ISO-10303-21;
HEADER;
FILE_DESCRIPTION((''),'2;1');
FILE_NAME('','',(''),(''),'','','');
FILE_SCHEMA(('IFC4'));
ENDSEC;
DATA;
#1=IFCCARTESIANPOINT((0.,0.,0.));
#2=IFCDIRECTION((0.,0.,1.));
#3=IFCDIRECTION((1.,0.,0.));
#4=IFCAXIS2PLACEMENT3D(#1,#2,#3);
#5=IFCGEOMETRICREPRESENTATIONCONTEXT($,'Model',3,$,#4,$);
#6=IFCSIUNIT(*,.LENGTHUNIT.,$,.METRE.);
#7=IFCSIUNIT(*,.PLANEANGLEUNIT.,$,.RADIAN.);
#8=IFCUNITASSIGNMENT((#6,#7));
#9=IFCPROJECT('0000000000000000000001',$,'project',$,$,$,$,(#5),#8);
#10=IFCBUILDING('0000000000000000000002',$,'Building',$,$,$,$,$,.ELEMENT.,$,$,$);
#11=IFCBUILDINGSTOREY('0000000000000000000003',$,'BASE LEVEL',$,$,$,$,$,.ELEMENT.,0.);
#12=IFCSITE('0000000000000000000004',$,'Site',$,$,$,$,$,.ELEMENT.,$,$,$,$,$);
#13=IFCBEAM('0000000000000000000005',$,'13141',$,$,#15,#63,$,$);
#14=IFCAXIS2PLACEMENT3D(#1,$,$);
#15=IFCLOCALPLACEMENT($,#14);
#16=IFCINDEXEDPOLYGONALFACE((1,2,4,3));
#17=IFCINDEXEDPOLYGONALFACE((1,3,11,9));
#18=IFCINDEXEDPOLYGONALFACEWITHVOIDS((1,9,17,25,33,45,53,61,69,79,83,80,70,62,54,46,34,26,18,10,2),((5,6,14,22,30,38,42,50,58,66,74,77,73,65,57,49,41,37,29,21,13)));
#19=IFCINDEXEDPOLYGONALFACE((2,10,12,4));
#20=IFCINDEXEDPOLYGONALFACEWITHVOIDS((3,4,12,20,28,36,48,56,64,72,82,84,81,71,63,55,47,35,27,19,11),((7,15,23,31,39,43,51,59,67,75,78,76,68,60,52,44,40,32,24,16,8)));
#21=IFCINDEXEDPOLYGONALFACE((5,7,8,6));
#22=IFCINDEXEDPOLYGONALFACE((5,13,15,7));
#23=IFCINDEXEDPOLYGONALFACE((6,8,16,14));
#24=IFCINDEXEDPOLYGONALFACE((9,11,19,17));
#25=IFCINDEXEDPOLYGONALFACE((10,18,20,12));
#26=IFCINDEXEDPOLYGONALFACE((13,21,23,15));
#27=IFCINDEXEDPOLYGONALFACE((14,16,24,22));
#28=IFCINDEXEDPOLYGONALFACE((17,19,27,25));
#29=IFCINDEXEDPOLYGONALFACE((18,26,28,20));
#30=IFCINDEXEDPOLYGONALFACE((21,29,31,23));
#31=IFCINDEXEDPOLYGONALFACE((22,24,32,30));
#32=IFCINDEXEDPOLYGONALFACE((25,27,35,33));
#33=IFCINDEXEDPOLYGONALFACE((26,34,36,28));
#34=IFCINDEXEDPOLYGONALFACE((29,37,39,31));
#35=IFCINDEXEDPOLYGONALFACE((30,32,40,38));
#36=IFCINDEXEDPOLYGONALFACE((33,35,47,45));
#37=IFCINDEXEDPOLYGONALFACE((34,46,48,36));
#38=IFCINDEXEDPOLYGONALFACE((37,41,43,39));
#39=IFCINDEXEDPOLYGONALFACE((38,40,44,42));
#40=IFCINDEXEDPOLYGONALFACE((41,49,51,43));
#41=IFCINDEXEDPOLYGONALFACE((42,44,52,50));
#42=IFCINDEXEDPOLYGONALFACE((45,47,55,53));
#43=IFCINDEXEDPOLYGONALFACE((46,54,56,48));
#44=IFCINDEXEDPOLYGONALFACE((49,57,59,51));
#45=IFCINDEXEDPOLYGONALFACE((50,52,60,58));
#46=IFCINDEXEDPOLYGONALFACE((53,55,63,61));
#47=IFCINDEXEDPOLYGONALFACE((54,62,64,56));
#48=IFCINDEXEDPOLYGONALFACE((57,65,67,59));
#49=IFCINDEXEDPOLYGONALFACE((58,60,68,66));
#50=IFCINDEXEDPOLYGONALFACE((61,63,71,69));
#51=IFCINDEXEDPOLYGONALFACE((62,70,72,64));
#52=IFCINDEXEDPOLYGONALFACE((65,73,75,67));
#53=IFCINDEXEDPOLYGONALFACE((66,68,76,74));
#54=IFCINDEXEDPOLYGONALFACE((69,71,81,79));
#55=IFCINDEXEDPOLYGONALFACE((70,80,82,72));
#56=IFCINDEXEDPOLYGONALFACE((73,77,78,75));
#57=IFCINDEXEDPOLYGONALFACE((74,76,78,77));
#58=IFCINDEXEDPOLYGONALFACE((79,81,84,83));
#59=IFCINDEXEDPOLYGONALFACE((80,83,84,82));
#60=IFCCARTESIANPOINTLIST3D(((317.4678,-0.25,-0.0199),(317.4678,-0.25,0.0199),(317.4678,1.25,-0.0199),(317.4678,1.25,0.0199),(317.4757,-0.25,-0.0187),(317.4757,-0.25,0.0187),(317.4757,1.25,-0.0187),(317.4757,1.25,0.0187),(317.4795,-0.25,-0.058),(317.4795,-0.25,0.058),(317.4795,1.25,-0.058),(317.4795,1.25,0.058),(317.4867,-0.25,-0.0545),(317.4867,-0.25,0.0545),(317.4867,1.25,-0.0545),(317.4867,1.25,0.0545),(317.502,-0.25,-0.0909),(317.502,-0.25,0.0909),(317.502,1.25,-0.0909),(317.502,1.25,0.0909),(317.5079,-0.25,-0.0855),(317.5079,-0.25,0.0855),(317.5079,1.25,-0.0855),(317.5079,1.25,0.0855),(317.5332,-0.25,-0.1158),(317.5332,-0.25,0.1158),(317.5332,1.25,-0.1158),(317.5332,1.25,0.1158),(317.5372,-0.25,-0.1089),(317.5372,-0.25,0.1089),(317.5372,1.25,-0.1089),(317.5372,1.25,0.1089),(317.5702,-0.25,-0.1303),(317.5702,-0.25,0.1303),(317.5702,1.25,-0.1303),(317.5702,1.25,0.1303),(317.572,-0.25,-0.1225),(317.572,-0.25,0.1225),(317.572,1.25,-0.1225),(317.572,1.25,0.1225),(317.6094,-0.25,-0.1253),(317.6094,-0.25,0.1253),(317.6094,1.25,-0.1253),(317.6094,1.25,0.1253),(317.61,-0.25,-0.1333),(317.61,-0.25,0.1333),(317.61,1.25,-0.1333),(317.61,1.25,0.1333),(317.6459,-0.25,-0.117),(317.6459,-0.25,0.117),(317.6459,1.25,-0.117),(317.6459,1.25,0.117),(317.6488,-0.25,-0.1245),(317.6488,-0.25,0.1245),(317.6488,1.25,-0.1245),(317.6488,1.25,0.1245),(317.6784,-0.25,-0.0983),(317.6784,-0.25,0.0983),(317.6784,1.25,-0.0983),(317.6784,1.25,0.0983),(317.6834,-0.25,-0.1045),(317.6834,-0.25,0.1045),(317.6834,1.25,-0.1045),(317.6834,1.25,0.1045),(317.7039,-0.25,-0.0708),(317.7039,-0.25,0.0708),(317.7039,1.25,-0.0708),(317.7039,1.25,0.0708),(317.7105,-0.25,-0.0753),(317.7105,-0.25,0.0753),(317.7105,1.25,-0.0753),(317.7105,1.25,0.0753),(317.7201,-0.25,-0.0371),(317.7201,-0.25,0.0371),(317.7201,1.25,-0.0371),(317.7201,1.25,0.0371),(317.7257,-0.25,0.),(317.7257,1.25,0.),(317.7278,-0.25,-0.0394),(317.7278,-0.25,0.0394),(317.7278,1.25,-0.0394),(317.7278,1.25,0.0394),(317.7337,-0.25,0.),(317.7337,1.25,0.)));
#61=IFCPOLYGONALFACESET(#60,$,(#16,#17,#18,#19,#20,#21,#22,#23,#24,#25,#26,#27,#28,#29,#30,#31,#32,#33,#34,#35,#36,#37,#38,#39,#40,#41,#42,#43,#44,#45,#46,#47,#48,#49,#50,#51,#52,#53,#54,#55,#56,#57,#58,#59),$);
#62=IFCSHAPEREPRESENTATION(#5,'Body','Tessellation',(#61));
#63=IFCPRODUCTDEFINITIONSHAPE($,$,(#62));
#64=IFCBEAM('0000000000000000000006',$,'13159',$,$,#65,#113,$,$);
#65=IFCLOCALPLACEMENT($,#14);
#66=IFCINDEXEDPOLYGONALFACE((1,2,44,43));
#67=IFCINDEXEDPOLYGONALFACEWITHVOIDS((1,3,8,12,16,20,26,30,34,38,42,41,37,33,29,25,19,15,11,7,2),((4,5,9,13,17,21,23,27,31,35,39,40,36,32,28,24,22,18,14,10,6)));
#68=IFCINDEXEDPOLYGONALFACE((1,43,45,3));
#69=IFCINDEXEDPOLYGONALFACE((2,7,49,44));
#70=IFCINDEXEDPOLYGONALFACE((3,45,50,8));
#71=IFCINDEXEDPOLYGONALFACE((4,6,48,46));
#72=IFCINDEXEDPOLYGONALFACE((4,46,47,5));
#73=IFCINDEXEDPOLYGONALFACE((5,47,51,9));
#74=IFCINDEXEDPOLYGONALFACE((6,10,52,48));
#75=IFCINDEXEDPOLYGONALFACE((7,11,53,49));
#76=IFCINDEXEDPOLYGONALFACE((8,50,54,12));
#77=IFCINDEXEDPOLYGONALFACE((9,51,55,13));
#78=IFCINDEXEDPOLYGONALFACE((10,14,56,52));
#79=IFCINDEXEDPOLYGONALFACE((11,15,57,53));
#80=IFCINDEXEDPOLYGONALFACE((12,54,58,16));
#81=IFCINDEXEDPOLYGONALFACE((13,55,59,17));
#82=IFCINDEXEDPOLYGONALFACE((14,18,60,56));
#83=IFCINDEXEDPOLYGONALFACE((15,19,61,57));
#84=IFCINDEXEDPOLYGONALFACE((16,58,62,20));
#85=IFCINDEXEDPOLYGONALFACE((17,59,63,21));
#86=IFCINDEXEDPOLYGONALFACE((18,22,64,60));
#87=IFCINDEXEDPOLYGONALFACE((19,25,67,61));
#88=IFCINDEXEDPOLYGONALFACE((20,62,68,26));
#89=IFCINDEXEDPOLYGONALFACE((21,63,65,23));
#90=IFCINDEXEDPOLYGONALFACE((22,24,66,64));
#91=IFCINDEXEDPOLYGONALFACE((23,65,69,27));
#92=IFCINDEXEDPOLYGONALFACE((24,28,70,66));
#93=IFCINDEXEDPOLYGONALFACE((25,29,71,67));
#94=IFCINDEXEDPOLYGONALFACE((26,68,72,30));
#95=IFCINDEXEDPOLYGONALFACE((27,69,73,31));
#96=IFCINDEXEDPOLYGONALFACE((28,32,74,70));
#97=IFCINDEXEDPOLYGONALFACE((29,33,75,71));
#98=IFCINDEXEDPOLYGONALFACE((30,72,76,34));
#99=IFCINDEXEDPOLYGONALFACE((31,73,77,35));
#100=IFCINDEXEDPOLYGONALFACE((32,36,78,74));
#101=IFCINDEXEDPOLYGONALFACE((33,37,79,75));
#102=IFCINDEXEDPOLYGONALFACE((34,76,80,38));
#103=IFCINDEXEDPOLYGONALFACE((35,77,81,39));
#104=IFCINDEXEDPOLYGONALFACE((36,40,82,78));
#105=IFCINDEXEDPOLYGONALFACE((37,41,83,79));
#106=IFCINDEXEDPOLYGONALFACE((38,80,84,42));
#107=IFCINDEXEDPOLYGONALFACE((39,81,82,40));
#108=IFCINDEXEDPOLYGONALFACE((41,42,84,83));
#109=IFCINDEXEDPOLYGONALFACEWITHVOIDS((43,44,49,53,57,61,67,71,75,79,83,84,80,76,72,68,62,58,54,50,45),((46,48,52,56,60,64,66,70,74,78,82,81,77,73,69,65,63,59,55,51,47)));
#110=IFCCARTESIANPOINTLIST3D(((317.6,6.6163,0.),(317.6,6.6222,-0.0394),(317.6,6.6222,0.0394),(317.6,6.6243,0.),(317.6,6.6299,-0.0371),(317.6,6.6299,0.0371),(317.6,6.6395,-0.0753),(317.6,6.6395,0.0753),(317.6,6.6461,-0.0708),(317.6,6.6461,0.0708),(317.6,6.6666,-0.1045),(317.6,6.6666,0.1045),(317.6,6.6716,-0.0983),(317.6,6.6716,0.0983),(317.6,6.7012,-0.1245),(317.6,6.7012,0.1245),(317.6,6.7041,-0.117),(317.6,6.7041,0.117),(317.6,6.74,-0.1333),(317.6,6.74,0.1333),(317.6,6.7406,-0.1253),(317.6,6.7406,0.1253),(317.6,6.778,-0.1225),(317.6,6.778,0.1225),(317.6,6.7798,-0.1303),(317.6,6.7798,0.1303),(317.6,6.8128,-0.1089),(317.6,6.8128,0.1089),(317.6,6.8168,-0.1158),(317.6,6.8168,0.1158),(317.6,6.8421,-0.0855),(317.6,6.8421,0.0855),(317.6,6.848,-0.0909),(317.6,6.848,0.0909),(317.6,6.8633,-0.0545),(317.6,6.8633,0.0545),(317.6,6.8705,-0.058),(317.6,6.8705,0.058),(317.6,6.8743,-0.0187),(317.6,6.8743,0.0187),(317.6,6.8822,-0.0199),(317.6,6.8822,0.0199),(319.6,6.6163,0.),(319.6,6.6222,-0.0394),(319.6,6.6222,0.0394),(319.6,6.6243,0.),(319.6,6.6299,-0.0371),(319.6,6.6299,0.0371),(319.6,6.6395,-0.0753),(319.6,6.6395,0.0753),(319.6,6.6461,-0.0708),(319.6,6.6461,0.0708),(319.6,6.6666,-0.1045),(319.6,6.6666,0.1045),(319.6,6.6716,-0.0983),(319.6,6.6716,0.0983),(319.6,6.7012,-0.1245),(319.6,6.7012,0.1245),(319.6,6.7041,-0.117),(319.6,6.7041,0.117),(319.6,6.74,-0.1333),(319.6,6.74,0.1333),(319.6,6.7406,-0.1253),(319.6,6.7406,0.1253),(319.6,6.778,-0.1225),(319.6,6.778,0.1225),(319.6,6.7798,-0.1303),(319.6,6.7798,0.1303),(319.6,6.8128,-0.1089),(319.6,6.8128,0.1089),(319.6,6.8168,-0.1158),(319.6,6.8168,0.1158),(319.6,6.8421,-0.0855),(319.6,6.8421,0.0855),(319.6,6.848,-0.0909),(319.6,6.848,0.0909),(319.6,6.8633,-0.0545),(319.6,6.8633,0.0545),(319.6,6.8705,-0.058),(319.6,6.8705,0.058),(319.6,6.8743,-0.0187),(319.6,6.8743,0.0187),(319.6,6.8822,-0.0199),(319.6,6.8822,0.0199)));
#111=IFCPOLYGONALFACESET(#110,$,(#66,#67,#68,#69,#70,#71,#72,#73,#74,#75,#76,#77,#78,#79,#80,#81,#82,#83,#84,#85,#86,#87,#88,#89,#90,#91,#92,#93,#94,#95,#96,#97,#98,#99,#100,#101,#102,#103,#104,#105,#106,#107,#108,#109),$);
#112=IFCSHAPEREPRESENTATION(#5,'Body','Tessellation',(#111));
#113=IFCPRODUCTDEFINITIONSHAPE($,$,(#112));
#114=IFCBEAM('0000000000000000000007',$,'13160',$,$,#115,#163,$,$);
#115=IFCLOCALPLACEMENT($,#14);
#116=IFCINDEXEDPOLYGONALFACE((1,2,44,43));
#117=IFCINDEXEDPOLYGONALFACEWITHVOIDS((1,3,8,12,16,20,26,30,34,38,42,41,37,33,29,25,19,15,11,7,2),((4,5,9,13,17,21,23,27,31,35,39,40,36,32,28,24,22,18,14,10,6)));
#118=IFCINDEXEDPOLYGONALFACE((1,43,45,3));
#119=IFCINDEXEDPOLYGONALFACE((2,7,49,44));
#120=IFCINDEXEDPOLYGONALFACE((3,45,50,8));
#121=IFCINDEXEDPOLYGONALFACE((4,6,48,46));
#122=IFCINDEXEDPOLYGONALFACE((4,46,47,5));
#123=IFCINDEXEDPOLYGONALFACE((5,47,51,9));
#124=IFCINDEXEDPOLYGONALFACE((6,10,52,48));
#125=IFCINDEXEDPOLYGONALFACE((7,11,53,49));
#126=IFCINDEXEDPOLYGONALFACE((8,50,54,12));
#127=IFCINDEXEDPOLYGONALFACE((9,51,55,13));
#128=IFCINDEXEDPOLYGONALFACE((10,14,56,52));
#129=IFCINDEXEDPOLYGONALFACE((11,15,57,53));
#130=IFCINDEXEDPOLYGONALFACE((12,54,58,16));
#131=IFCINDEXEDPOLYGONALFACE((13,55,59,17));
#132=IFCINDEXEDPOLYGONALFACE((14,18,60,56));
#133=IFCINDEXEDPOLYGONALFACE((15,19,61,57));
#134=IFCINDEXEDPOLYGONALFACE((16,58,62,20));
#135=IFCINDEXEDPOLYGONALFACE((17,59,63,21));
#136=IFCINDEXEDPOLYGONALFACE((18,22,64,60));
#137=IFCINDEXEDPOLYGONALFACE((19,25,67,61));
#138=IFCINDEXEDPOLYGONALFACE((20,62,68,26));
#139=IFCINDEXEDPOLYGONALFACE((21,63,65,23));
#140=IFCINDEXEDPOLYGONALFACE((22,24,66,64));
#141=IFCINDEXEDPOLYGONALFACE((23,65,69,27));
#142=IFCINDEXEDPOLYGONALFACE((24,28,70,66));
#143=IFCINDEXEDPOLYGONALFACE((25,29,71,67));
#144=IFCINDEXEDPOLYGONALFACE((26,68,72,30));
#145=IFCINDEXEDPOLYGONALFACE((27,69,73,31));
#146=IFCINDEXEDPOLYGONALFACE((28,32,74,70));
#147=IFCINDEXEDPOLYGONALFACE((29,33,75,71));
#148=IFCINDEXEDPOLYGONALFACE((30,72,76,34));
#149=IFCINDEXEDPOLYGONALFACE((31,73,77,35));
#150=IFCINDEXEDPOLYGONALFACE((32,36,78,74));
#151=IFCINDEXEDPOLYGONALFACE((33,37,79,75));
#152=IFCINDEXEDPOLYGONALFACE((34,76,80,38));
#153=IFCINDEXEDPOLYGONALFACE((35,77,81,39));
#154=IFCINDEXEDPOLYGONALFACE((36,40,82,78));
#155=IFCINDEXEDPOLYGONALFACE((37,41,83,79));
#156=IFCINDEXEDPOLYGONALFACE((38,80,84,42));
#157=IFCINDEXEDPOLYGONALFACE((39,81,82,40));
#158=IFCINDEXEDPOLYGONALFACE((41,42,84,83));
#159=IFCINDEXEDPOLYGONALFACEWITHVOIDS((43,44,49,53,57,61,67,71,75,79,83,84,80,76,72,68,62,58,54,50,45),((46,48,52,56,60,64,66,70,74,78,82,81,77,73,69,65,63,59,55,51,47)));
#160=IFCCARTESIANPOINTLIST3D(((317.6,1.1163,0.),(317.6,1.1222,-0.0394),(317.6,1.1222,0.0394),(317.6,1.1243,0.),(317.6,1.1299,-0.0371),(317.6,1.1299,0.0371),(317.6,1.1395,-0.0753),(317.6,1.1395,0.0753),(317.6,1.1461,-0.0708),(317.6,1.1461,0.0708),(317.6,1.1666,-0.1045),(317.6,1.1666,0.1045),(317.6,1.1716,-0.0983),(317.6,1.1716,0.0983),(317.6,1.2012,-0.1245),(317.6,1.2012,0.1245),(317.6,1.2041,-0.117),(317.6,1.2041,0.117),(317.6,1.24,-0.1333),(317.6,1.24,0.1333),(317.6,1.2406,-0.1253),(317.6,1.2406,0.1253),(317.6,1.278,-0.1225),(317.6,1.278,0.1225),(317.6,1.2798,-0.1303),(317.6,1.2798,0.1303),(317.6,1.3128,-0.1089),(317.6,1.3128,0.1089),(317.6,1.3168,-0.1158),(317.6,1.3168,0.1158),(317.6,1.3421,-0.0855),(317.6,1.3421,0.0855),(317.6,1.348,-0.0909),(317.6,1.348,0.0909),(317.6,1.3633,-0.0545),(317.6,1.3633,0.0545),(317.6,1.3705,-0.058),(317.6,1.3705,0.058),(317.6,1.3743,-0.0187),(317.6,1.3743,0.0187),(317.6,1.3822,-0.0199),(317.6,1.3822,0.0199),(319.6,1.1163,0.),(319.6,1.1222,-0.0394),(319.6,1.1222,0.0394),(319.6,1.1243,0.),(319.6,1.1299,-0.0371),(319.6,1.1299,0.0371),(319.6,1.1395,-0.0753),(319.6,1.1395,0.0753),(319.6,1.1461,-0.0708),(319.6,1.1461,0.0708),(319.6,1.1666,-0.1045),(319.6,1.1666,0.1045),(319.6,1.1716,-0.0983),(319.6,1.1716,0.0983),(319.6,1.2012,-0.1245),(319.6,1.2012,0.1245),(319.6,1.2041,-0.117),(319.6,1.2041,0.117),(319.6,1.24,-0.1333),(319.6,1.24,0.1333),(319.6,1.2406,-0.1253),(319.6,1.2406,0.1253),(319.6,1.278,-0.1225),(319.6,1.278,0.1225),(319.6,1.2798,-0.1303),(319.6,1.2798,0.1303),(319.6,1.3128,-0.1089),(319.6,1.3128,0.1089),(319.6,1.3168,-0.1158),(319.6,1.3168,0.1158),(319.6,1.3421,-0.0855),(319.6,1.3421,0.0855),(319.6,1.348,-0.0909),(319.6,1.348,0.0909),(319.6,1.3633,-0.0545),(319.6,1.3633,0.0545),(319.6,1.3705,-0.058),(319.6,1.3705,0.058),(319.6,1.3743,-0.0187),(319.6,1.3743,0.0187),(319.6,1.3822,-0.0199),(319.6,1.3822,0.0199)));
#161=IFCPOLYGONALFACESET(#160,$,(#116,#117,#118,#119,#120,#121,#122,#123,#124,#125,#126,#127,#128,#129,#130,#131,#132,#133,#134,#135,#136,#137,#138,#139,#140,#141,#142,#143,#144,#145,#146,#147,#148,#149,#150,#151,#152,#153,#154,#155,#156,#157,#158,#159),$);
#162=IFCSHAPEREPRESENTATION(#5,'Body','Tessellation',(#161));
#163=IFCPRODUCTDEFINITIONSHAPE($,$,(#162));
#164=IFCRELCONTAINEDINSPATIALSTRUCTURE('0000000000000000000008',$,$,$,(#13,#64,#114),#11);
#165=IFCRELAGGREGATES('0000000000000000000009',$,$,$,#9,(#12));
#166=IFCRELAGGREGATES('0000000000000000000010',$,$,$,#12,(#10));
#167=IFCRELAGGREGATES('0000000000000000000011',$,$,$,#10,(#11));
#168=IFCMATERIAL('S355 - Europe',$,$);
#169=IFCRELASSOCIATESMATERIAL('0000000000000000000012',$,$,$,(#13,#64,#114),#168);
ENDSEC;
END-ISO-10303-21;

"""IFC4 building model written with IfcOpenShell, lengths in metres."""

from ifc_helpers import new_model, si_unit, frame, origin_with_axes, origin_2d_with_axis, place, context, project, spatial, hollow_circle, extrude, material, material_profile, profile_set, profile_usage, element, save


model = new_model("IFC4")

# Units and contexts
model_context = context("Model", 3, world=origin_with_axes())
ifc_project = project(units=[si_unit("LENGTHUNIT", "METRE"), si_unit("PLANEANGLEUNIT", "RADIAN")], contexts=[model_context])

# Site, building, storey
site = spatial("IfcSite", under=ifc_project, Name="Site", CompositionType="ELEMENT")
building = spatial("IfcBuilding", under=site, Name="Building", CompositionType="ELEMENT")
storey = spatial("IfcBuildingStorey", under=building, Name="BASE LEVEL", CompositionType="ELEMENT", Elevation=0.0)

# Shared definitions
ifc_material = material(Name="S355 - Europe")

# Beams
ifc_material_profile_1 = material_profile(ifc_material, hollow_circle(Radius=0.1337, WallThickness=0.008, at=origin_2d_with_axis()))
ifc_profile_set_1 = profile_set([ifc_material_profile_1])
ifc_profile_usage_1 = profile_usage(ifc_profile_set_1, cardinal=10)
beam_1_placement = place(None, frame((317.6, 1.25, 0.0), z_axis=(0.0, -1.0, 0.0), x_axis=(1.0, 0.0, 0.0)))
element("IfcBeam", 1, at=beam_1_placement, inside=storey, material=ifc_profile_usage_1, Name="13141", context=model_context, shape_type="SweptSolid", body=[
    extrude(hollow_circle(Radius=0.1337, WallThickness=0.008, at=origin_2d_with_axis()), origin_with_axes(), (0.0, 0.0, 1.0), 1.5),
])
ifc_material_profile_2 = material_profile(ifc_material, hollow_circle(Radius=0.1337, WallThickness=0.008, at=origin_2d_with_axis()))
ifc_profile_set_2 = profile_set([ifc_material_profile_2])
ifc_profile_usage_2 = profile_usage(ifc_profile_set_2, cardinal=10)
beam_2_placement = place(None, frame((319.6, 6.75, 0.0), z_axis=(-1.0, 0.0, 0.0), x_axis=(0.0, -1.0, 0.0)))
element("IfcBeam", 2, at=beam_2_placement, inside=storey, material=ifc_profile_usage_2, Name="13159", context=model_context, shape_type="SweptSolid", body=[
    extrude(hollow_circle(Radius=0.1337, WallThickness=0.008, at=origin_2d_with_axis()), origin_with_axes(), (0.0, 0.0, 1.0), 2.0),
])
ifc_material_profile_3 = material_profile(ifc_material, hollow_circle(Radius=0.1337, WallThickness=0.008, at=origin_2d_with_axis()))
ifc_profile_set_3 = profile_set([ifc_material_profile_3])
ifc_profile_usage_3 = profile_usage(ifc_profile_set_3, cardinal=10)
beam_3_placement = place(None, frame((319.6, 1.25, 0.0), z_axis=(-1.0, 0.0, 0.0), x_axis=(0.0, -1.0, 0.0)))
element("IfcBeam", 3, at=beam_3_placement, inside=storey, material=ifc_profile_usage_3, Name="13160", context=model_context, shape_type="SweptSolid", body=[
    extrude(hollow_circle(Radius=0.1337, WallThickness=0.008, at=origin_2d_with_axis()), origin_with_axes(), (0.0, 0.0, 1.0), 2.0),
])

save(model, "model.ifc")
